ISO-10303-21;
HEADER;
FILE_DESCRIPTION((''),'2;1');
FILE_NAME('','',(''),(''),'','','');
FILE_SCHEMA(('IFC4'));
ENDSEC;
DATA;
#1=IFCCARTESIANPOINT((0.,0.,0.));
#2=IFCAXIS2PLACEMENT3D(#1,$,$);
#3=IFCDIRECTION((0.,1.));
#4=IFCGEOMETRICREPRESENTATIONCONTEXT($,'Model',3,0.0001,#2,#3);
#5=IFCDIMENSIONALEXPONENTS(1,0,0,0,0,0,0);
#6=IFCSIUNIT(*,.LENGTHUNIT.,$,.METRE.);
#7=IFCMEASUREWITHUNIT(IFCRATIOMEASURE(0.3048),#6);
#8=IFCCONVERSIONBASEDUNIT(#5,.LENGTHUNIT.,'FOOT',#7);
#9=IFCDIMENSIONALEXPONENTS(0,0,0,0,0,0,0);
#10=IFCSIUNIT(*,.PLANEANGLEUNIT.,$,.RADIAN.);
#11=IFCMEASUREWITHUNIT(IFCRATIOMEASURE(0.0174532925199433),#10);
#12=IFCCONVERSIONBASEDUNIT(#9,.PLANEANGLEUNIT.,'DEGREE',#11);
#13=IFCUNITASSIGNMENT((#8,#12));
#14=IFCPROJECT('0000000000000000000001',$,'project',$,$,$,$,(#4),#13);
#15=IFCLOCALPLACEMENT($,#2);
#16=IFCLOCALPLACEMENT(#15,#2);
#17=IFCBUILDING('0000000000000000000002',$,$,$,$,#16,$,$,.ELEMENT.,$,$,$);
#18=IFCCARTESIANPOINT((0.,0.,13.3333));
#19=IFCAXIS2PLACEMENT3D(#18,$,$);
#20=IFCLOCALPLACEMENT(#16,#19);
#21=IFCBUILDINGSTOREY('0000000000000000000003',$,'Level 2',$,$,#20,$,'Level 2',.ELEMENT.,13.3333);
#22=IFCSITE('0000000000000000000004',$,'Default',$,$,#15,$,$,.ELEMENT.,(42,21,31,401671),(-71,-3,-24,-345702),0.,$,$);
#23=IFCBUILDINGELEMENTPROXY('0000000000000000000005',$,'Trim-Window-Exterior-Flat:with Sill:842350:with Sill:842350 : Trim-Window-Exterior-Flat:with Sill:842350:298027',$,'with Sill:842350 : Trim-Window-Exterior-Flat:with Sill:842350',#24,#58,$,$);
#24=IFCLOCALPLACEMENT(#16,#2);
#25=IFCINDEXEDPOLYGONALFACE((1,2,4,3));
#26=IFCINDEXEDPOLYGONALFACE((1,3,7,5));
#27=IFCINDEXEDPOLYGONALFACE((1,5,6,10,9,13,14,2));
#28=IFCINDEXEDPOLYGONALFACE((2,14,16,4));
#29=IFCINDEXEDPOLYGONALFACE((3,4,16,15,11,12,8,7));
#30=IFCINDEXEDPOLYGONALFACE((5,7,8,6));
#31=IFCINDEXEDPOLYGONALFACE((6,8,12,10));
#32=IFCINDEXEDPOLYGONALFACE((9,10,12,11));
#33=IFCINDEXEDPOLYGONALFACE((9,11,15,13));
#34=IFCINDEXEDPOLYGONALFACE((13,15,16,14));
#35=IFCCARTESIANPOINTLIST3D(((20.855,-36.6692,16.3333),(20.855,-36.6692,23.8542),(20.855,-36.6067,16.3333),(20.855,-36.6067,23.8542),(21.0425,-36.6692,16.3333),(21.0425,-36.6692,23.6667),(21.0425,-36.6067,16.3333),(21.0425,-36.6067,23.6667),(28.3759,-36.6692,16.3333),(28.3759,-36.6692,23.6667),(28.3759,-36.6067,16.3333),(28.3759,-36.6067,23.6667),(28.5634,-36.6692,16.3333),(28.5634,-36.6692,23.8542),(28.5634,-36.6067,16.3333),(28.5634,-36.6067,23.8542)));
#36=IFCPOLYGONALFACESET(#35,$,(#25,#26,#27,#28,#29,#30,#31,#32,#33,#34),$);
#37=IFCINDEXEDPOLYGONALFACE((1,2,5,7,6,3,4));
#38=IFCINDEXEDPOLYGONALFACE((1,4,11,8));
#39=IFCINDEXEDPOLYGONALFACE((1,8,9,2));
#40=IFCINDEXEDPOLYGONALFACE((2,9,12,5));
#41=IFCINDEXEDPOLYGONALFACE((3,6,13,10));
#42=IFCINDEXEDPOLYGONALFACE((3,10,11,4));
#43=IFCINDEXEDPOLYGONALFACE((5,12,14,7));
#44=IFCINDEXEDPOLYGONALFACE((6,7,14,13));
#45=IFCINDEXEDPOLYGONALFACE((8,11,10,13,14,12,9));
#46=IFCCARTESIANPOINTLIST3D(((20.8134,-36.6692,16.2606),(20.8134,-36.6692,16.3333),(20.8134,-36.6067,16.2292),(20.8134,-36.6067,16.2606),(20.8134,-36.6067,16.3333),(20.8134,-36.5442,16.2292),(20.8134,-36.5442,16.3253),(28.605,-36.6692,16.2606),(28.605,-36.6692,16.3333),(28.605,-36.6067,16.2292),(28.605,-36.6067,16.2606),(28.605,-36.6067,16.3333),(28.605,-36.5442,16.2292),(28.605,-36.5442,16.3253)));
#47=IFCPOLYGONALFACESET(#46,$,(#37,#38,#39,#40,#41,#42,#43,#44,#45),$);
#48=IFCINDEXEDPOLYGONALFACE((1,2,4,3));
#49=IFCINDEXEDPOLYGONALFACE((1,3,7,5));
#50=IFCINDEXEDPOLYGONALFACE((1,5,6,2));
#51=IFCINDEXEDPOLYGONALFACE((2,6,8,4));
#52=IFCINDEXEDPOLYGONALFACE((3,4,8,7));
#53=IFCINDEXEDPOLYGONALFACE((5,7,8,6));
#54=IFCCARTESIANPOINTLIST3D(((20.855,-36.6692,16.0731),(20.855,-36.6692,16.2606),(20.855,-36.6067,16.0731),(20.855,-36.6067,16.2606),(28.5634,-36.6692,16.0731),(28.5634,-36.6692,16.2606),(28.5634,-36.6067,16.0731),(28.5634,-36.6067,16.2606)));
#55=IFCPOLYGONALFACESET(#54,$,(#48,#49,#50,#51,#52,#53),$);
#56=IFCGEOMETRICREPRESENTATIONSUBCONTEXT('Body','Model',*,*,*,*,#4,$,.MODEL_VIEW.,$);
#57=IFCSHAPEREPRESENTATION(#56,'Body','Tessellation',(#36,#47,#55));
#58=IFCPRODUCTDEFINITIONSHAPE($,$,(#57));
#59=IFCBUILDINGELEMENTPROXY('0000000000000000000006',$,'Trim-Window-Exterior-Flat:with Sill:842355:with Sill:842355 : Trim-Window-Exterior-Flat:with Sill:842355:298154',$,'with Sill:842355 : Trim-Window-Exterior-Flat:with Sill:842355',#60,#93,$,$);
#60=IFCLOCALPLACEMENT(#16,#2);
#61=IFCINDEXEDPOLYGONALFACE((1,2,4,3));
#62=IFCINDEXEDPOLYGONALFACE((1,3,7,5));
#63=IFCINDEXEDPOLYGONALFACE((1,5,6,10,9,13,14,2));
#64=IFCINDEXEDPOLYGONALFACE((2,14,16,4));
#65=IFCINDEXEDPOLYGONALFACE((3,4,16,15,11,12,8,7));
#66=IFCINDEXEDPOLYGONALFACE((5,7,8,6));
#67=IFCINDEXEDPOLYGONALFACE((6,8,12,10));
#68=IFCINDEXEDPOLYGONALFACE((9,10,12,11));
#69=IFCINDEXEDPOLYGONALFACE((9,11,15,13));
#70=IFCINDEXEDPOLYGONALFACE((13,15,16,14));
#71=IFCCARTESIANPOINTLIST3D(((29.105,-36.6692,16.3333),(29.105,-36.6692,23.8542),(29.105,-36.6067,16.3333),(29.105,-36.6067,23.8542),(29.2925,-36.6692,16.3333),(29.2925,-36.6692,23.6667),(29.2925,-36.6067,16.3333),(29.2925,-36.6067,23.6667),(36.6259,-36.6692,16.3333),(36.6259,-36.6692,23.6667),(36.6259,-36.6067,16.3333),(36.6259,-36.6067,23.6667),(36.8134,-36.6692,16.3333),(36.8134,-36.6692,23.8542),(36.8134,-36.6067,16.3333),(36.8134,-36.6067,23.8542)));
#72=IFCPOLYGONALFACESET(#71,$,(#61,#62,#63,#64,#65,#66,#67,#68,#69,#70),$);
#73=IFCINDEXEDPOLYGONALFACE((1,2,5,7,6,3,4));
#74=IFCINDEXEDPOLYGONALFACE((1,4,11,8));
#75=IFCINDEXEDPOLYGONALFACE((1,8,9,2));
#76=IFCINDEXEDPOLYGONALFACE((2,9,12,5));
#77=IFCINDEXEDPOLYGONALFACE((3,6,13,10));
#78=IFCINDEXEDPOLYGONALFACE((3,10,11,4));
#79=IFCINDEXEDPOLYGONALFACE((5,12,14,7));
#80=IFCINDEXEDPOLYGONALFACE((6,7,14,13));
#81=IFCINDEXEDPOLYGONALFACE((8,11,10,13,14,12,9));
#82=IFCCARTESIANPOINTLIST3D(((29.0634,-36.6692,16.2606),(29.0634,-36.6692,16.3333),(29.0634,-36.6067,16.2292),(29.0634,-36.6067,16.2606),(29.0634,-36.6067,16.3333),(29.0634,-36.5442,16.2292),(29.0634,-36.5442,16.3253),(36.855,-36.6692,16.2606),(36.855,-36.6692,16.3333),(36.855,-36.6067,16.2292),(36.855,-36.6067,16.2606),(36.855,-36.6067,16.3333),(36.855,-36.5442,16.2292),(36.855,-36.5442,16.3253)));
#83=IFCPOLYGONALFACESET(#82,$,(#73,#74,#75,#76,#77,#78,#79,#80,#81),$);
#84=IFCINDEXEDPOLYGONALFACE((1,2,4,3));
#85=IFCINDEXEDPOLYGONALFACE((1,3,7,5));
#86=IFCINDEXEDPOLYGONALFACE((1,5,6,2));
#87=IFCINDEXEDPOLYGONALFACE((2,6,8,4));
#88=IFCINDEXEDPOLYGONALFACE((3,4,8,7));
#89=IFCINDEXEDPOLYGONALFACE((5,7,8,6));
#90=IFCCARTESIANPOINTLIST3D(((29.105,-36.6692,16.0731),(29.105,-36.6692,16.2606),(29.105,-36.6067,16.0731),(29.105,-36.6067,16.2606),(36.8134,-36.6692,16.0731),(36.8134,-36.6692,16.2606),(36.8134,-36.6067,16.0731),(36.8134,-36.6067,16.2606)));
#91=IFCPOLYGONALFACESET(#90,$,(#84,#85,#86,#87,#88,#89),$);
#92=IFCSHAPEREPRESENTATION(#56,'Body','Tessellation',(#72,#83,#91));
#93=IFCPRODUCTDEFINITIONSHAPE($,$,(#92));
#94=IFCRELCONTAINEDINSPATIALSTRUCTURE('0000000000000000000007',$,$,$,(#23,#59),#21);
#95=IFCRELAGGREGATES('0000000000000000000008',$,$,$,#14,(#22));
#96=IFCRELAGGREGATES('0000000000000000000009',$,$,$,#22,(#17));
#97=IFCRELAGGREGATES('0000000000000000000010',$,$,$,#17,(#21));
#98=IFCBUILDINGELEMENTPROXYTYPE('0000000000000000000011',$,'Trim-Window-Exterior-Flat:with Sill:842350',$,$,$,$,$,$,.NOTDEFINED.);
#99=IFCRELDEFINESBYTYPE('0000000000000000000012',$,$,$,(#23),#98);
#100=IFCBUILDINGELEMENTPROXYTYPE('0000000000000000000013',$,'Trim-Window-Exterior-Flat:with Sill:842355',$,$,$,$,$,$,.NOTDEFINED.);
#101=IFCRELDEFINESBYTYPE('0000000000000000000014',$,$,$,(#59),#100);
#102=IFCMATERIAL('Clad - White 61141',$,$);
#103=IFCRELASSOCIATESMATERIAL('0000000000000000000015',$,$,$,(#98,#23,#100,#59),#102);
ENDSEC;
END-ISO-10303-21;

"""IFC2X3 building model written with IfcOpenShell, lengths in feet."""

from ifc_helpers import new_model, entity, si_unit, converted_unit, direction, frame, frame_2d, origin, place, context, subcontext, project, spatial, polyline, rectangle, outline, extrude, source, transform, mapped, material, type_object, type_shapes, element, save


model = new_model("IFC2X3")

# Units and contexts
model_context = context("Model", 3, precision=0.0001, world=origin(), true_north=direction((0.0, 1.0)))
body_context = subcontext(model_context, "Body", "Model", "MODEL_VIEW")
ifc_project = project(units=[converted_unit("LENGTHUNIT", "FOOT", entity("IfcRatioMeasure", 0.3048), si_unit("LENGTHUNIT", "METRE"), dimensions=[1, 0, 0, 0, 0, 0, 0]), converted_unit("PLANEANGLEUNIT", "DEGREE", entity("IfcRatioMeasure", 0.0174532925199433), si_unit("PLANEANGLEUNIT", "RADIAN"), dimensions=[0, 0, 0, 0, 0, 0, 0])], contexts=[model_context])

# Site, building, storey
site_placement = place(None, origin())
site = spatial("IfcSite", under=ifc_project, at=site_placement, Name="Default", CompositionType="ELEMENT", RefLatitude=(42, 21, 31, 401671), RefLongitude=(-71, -3, -24, -345702), RefElevation=0.0)
building_placement = place(site_placement, origin())
building = spatial("IfcBuilding", under=site, at=building_placement, CompositionType="ELEMENT")
storey_placement = place(building_placement, frame((0.0, 0.0, 13.3333)))
storey = spatial("IfcBuildingStorey", under=building, at=storey_placement, Name="Level 2", LongName="Level 2", CompositionType="ELEMENT", Elevation=13.3333)

# Building element proxies
ifc_material_1 = material(Name="Clad - White 61141")
building_element_proxy_type_1 = type_object("IfcBuildingElementProxyType", Name="Trim-Window-Exterior-Flat:with Sill:842350", PredefinedType="NOTDEFINED", material=ifc_material_1)
shared_shape_1 = source(origin(), body_context, "Body", "SweptSolid", [
    extrude(outline(polyline([(-3.8542, -3.7135), (-3.6667, -3.7135), (-3.6667, 3.6198), (3.6667, 3.6198), (3.6667, -3.7135), (3.8542, -3.7135), (3.8542, 3.8073), (-3.8542, 3.8073), (-3.8542, -3.7135)])), frame((24.7092, -36.6692, 20.0469), z_axis=(0.0, 1.0, 0.0), x_axis=(-1.0, 0.0, 0.0)), (0.0, 0.0, 1.0), 0.0625),
    extrude(outline(polyline([(0.0, -0.0525), (0.0625, -0.0525), (0.0625, 0.0436), (0.0, 0.0517), (-0.0625, 0.0517), (-0.0625, -0.0211), (0.0, -0.0211), (0.0, -0.0525)])), frame((20.8134, -36.6067, 16.2816), z_axis=(1.0, 0.0, 0.0), x_axis=(0.0, 1.0, 0.0)), (0.0, 0.0, 1.0), 7.7917),
    extrude(rectangle(XDim=0.0625, YDim=7.7083, at=frame_2d((0.0, 0.0), x_axis=(1.0, 0.0))), frame((24.7092, -36.638, 16.0731), z_axis=(0.0, 0.0, 1.0), x_axis=(0.0, -1.0, 0.0)), (0.0, 0.0, 1.0), 0.1875),
])
type_shapes(building_element_proxy_type_1, [shared_shape_1])
proxy_1_placement = place(building_placement, origin())
element("IfcBuildingElementProxy", 1, at=proxy_1_placement, inside=storey, type_object=building_element_proxy_type_1, material=ifc_material_1, Name="Trim-Window-Exterior-Flat:with Sill:842350:with Sill:842350 : Trim-Window-Exterior-Flat:with Sill:842350:298027", ObjectType="with Sill:842350 : Trim-Window-Exterior-Flat:with Sill:842350", context=body_context, shape_type="MappedRepresentation", body=[
    mapped(shared_shape_1, transform((0.0, 0.0, 0.0), scale=1.0)),
])
building_element_proxy_type_2 = type_object("IfcBuildingElementProxyType", Name="Trim-Window-Exterior-Flat:with Sill:842355", PredefinedType="NOTDEFINED", material=ifc_material_1)
shared_shape_2 = source(origin(), body_context, "Body", "SweptSolid", [
    extrude(outline(polyline([(-3.8542, -3.7135), (-3.6667, -3.7135), (-3.6667, 3.6198), (3.6667, 3.6198), (3.6667, -3.7135), (3.8542, -3.7135), (3.8542, 3.8073), (-3.8542, 3.8073), (-3.8542, -3.7135)])), frame((32.9592, -36.6692, 20.0469), z_axis=(0.0, 1.0, 0.0), x_axis=(-1.0, 0.0, 0.0)), (0.0, 0.0, 1.0), 0.0625),
    extrude(outline(polyline([(0.0, -0.0525), (0.0625, -0.0525), (0.0625, 0.0436), (0.0, 0.0517), (-0.0625, 0.0517), (-0.0625, -0.0211), (0.0, -0.0211), (0.0, -0.0525)])), frame((29.0634, -36.6067, 16.2816), z_axis=(1.0, 0.0, 0.0), x_axis=(0.0, 1.0, 0.0)), (0.0, 0.0, 1.0), 7.7917),
    extrude(rectangle(XDim=0.0625, YDim=7.7083, at=frame_2d((0.0, 0.0), x_axis=(1.0, 0.0))), frame((32.9592, -36.638, 16.0731), z_axis=(0.0, 0.0, 1.0), x_axis=(0.0, -1.0, 0.0)), (0.0, 0.0, 1.0), 0.1875),
])
type_shapes(building_element_proxy_type_2, [shared_shape_2])
proxy_2_placement = place(building_placement, origin())
element("IfcBuildingElementProxy", 2, at=proxy_2_placement, inside=storey, type_object=building_element_proxy_type_2, material=ifc_material_1, Name="Trim-Window-Exterior-Flat:with Sill:842355:with Sill:842355 : Trim-Window-Exterior-Flat:with Sill:842355:298154", ObjectType="with Sill:842355 : Trim-Window-Exterior-Flat:with Sill:842355", context=body_context, shape_type="MappedRepresentation", body=[
    mapped(shared_shape_2, transform((0.0, 0.0, 0.0), scale=1.0)),
])

save(model, "model.ifc")
